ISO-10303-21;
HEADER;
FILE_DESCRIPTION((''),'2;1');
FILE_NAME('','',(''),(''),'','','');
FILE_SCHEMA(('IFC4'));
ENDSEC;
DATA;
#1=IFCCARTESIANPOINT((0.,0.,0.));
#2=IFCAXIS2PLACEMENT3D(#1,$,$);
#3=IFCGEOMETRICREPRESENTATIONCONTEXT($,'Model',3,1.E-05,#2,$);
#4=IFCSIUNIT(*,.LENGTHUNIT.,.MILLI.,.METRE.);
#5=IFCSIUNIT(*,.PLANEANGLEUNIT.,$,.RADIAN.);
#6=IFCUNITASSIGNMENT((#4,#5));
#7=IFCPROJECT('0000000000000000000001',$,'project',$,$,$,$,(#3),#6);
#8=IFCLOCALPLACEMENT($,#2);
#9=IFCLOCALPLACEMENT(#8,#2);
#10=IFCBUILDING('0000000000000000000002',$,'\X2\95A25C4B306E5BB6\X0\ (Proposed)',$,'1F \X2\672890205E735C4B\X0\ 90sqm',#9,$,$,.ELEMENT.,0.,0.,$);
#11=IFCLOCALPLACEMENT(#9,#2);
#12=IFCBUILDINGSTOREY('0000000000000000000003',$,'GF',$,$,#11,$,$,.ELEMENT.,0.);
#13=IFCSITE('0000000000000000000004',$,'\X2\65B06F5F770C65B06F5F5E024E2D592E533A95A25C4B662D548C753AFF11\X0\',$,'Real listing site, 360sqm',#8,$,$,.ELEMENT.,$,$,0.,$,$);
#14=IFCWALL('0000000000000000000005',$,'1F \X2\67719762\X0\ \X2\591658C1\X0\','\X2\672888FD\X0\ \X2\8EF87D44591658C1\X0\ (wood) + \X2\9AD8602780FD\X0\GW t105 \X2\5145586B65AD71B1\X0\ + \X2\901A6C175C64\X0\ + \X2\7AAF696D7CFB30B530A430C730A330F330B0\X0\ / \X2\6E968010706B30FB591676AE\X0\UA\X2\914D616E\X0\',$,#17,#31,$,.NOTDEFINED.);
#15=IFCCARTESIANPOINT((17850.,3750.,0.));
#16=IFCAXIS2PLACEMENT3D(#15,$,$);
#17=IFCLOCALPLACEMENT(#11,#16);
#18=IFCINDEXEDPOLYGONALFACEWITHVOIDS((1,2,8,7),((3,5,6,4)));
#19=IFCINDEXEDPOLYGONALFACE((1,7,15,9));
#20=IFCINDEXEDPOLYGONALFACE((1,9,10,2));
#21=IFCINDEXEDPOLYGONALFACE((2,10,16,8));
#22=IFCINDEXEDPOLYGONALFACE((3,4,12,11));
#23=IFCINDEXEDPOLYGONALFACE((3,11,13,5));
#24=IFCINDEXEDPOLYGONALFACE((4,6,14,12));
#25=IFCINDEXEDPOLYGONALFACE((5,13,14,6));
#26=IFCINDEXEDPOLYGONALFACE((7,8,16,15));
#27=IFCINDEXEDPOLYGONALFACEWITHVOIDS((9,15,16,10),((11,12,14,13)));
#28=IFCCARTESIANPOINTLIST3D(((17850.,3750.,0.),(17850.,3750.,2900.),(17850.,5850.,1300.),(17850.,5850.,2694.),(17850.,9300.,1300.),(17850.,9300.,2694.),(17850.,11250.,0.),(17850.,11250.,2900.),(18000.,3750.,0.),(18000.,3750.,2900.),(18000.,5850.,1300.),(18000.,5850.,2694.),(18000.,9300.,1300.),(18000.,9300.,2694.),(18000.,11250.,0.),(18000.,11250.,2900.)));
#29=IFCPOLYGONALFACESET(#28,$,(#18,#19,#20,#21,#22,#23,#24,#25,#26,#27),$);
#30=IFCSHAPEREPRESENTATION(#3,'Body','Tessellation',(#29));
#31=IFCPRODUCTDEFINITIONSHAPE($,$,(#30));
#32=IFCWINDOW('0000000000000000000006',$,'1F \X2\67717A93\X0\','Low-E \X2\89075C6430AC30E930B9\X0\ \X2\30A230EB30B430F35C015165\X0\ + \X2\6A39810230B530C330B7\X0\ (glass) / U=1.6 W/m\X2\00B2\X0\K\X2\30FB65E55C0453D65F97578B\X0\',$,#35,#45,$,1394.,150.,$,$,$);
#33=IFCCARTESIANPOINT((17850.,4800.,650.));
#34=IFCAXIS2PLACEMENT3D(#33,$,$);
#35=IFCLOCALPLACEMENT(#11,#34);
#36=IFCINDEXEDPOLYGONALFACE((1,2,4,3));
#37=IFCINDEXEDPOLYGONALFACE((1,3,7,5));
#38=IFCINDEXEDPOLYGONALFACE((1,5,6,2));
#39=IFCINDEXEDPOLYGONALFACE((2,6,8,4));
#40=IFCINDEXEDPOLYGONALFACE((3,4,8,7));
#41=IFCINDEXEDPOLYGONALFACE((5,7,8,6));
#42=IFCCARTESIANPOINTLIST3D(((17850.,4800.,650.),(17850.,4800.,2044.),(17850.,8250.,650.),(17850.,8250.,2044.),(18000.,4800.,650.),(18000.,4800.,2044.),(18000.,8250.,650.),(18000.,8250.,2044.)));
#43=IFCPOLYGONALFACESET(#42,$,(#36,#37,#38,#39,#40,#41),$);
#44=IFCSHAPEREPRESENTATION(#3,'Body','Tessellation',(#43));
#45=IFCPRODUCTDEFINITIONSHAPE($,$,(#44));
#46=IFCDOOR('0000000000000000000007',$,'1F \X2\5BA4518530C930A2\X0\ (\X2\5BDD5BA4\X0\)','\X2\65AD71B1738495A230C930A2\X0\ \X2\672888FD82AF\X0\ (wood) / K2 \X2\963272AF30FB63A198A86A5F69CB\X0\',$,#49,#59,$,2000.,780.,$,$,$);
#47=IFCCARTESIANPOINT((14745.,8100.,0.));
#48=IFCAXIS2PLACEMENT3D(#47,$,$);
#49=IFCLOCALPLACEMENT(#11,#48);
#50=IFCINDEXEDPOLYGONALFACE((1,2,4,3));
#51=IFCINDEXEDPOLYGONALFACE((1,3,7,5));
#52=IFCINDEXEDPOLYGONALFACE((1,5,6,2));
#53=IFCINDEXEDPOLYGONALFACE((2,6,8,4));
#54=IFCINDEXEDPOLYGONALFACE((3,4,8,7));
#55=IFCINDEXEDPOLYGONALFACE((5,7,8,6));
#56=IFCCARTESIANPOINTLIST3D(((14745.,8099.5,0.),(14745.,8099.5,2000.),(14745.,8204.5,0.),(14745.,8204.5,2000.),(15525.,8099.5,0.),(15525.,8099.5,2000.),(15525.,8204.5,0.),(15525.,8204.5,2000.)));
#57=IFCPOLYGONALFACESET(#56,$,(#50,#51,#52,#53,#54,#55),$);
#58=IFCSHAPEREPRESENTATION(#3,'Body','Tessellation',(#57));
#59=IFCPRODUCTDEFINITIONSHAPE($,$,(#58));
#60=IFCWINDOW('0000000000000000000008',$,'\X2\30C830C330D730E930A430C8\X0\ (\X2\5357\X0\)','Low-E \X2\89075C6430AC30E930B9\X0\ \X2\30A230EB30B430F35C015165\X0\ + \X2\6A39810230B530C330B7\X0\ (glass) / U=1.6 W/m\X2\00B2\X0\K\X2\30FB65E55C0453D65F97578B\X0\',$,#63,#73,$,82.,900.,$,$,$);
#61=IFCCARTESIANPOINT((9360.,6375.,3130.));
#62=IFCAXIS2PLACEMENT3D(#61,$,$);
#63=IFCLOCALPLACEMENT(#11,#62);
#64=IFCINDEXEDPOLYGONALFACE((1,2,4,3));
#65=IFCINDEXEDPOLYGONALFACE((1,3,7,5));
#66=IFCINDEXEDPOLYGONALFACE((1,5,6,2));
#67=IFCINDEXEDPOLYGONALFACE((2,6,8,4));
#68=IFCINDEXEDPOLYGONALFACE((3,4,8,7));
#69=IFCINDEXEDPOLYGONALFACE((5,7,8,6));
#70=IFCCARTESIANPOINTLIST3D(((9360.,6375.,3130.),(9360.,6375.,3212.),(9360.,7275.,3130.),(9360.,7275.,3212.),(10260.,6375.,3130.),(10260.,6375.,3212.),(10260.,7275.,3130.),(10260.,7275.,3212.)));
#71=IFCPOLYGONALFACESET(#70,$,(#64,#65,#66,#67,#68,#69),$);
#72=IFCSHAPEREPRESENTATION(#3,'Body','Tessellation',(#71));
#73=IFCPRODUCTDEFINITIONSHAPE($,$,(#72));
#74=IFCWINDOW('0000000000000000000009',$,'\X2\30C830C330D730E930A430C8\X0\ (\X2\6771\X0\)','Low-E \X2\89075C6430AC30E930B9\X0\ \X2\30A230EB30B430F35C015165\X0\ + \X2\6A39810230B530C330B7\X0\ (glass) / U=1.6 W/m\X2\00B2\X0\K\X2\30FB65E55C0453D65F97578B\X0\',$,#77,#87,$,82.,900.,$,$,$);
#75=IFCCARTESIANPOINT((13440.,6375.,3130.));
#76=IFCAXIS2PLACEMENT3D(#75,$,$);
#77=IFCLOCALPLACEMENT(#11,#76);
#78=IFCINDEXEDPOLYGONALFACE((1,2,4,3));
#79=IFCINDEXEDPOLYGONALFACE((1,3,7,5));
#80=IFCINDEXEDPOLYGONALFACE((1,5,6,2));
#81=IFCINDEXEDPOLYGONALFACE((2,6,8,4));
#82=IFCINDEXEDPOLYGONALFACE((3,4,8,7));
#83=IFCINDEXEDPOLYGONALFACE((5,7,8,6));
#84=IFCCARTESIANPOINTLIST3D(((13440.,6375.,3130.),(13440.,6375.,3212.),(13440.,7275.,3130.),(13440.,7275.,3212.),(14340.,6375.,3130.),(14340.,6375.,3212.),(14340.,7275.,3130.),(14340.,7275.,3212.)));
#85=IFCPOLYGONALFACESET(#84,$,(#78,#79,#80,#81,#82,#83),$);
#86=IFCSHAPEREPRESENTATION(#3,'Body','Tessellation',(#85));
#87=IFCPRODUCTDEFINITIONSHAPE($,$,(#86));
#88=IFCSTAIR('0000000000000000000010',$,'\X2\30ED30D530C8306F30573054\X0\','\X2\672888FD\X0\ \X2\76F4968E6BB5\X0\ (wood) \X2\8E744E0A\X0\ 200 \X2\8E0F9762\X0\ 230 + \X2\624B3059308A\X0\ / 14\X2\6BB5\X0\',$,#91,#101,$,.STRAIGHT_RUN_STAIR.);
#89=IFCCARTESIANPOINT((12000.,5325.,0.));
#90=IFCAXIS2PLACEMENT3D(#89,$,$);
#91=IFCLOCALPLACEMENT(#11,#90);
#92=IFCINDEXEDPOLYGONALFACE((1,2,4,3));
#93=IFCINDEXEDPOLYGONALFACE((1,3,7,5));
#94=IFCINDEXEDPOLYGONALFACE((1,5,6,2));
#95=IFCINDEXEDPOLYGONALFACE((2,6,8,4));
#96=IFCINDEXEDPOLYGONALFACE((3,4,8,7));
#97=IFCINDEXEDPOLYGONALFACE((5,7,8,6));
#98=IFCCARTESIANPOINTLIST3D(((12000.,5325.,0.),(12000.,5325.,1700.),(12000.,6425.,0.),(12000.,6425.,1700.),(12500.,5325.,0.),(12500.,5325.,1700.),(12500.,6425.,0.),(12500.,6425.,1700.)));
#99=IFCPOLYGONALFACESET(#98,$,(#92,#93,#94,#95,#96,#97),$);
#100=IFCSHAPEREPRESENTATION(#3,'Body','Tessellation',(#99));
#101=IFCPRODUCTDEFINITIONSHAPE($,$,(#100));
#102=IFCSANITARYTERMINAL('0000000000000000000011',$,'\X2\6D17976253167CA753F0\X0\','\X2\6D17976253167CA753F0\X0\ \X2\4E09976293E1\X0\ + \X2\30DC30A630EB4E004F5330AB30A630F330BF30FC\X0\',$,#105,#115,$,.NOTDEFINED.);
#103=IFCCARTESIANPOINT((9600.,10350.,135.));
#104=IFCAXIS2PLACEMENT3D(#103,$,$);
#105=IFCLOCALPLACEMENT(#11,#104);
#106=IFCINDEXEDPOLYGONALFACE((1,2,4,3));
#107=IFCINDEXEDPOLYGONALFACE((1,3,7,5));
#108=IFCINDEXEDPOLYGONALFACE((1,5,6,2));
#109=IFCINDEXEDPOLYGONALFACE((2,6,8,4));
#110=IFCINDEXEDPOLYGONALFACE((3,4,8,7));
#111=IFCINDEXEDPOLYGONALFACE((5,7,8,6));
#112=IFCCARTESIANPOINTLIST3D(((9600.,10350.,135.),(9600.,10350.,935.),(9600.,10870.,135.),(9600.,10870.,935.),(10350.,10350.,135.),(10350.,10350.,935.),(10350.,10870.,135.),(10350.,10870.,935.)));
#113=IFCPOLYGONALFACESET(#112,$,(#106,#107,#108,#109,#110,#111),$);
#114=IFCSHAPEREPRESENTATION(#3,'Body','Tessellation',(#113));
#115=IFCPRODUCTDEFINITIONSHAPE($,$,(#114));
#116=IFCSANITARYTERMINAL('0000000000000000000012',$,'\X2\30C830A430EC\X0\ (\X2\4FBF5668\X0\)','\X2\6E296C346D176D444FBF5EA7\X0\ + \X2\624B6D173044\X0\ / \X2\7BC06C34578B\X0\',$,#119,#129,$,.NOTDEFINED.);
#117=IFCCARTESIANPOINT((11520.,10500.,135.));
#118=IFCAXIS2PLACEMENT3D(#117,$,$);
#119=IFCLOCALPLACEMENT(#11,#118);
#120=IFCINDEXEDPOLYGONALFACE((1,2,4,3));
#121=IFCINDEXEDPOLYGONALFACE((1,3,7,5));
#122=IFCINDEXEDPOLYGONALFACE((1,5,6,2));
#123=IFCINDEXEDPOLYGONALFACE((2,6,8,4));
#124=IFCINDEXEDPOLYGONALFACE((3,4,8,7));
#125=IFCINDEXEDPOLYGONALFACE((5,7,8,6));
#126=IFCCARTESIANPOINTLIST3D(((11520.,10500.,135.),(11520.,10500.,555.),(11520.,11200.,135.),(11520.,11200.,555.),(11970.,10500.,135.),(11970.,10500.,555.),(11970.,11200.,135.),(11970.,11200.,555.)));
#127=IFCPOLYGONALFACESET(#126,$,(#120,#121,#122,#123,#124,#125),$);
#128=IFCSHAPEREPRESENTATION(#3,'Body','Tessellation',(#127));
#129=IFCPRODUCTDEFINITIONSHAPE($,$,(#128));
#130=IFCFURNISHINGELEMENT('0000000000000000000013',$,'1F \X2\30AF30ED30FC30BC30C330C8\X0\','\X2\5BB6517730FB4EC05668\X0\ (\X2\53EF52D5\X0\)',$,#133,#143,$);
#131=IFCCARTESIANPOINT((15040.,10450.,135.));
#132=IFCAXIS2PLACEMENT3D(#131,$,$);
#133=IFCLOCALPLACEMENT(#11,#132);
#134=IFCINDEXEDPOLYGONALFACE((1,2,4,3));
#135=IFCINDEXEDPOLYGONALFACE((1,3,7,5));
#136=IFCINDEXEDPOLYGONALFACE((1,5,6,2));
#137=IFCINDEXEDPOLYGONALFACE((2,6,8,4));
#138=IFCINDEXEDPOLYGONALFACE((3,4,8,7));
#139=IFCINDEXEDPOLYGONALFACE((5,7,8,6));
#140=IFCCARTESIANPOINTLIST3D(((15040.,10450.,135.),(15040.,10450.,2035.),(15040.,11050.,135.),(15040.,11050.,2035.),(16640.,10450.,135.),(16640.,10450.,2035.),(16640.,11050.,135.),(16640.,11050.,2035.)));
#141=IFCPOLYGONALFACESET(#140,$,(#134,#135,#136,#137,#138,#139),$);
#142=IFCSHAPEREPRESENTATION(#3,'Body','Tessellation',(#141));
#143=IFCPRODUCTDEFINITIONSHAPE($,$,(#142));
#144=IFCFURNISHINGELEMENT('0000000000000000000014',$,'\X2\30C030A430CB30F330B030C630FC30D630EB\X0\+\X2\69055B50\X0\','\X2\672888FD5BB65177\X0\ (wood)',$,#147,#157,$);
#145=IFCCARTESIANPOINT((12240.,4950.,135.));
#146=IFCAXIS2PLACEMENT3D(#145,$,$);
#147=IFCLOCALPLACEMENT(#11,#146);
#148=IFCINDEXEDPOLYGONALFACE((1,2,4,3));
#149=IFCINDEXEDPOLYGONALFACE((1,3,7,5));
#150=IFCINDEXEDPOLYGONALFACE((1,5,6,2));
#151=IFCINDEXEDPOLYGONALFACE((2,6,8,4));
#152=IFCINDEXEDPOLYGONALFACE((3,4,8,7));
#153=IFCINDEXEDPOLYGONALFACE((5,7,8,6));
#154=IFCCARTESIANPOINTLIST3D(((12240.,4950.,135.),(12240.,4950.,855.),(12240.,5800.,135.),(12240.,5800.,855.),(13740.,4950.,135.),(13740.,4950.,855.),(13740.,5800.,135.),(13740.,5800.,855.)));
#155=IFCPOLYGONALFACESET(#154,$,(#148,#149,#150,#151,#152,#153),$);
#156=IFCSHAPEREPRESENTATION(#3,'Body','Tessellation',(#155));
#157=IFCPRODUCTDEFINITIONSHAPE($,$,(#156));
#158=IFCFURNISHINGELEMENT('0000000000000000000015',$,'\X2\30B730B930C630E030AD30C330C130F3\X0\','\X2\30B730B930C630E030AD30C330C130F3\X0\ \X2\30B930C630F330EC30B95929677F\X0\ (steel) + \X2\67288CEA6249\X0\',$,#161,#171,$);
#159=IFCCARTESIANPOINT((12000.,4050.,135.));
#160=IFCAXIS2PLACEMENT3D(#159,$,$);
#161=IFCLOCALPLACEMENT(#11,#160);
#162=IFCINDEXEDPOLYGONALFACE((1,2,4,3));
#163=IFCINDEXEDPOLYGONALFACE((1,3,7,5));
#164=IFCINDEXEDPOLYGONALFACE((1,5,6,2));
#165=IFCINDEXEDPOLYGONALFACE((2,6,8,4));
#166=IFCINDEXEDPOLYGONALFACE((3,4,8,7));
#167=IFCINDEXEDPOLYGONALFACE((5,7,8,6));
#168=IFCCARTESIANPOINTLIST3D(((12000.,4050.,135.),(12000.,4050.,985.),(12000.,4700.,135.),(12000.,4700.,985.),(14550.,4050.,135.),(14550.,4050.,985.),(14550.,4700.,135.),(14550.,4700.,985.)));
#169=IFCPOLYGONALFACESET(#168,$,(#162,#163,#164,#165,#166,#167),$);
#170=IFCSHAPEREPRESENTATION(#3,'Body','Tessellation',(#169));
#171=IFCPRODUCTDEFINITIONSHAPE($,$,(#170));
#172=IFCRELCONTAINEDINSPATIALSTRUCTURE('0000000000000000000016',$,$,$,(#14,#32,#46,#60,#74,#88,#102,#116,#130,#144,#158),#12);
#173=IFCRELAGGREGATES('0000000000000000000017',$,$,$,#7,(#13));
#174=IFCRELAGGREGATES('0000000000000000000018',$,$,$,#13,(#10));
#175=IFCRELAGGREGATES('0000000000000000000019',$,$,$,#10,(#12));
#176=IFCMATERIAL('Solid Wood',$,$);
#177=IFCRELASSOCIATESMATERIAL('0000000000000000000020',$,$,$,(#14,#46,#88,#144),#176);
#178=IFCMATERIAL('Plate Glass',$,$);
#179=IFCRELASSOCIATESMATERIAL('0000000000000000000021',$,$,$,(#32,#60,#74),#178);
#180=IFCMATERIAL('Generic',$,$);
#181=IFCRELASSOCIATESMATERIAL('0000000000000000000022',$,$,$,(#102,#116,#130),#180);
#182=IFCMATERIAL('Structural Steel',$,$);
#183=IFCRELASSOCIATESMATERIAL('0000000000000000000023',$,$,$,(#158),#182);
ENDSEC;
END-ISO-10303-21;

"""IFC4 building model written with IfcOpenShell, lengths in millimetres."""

from ifc_helpers import new_model, si_unit, frame, frame_2d, origin, place, context, project, spatial, rectangle, extrude, material, element, fill, save


model = new_model("IFC4")

# Units and contexts
model_context = context("Model", 3, precision=1e-05, world=origin())
ifc_project = project(units=[si_unit("LENGTHUNIT", "METRE", prefix="MILLI"), si_unit("PLANEANGLEUNIT", "RADIAN")], contexts=[model_context])

# Site, building, storey
site_placement = place(None, origin())
site = spatial("IfcSite", under=ifc_project, at=site_placement, Name="新潟県新潟市中央区関屋昭和町１", ObjectType="Real listing site, 360sqm", CompositionType="ELEMENT", RefElevation=0.0)
building_placement = place(site_placement, origin())
building = spatial("IfcBuilding", under=site, at=building_placement, Name="関屋の家 (Proposed)", ObjectType="1F 木造平屋 90sqm", CompositionType="ELEMENT", ElevationOfRefHeight=0.0, ElevationOfTerrain=0.0)
storey_placement = place(building_placement, origin())
storey = spatial("IfcBuildingStorey", under=building, at=storey_placement, Name="GF", CompositionType="ELEMENT", Elevation=0.0)

# Wall, opening, window
ifc_material_1 = material(Name="Solid Wood")
wall_1_placement = place(storey_placement, frame((17850.0, 3750.0, 0.0)))
wall_1 = element("IfcWall", 1, at=wall_1_placement, inside=storey, material=ifc_material_1, Name="1F 東面 外壁", Description="木製 軸組外壁 (wood) + 高性能GW t105 充填断熱 + 通気層 + 窯業系サイディング / 準耐火・外皮UA配慮", PredefinedType="NOTDEFINED", context=model_context, shape_type="SweptSolid", body=[
    extrude(rectangle(XDim=150.0, YDim=7500.0, at=frame_2d((75.0, 3750.0))), frame((17850.0, 3750.0, 0.0)), (0.0, 0.0, 1.0), 2900.0),
])
opening_placement = place(storey_placement, frame((17850.0, 4800.0, 650.0)))
opening = element("IfcOpeningElement", 2, at=opening_placement, cuts=wall_1, PredefinedType="NOTDEFINED", context=model_context, shape_type="SweptSolid", body=[
    extrude(rectangle(XDim=150.0, YDim=3450.0, at=frame_2d((75.0, 1725.0))), frame((17850.0, 4800.0, 650.0)), (0.0, 0.0, 1.0), 1394.0),
])
ifc_material_2 = material(Name="Plate Glass")
window_1_placement = place(storey_placement, frame((17850.0, 4800.0, 650.0)))
window_1 = element("IfcWindow", 3, at=window_1_placement, inside=storey, material=ifc_material_2, Name="1F 東窓", Description="Low-E 複層ガラス アルゴン封入 + 樹脂サッシ (glass) / U=1.6 W/m²K・日射取得型", OverallHeight=1394.0, OverallWidth=150.0, context=model_context, shape_type="SweptSolid", body=[
    extrude(rectangle(XDim=150.0, YDim=3450.0, at=frame_2d((75.0, 1725.0))), frame((17850.0, 4800.0, 650.0)), (0.0, 0.0, 1.0), 1394.0),
])
fill(opening, window_1)

# Door
door_placement = place(storey_placement, frame((14745.0, 8100.0, 0.0)))
element("IfcDoor", 4, at=door_placement, inside=storey, material=ifc_material_1, Name="1F 室内ドア (寝室)", Description="断熱玄関ドア 木製芯 (wood) / K2 防犯・採風機構", OverallHeight=2000.0, OverallWidth=780.0, context=model_context, shape_type="SweptSolid", body=[
    extrude(rectangle(XDim=780.0, YDim=105.0, at=frame_2d((390.0, 52.0))), frame((14745.0, 8100.0, 0.0)), (0.0, 0.0, 1.0), 2000.0),
])

# Windows
window_2_placement = place(storey_placement, frame((9360.0, 6375.0, 3130.0)))
element("IfcWindow", 5, at=window_2_placement, inside=storey, material=ifc_material_2, Name="トップライト (南)", Description="Low-E 複層ガラス アルゴン封入 + 樹脂サッシ (glass) / U=1.6 W/m²K・日射取得型", OverallHeight=82.0, OverallWidth=900.0, context=model_context, shape_type="SweptSolid", body=[
    extrude(rectangle(XDim=900.0, YDim=900.0, at=frame_2d((450.0, 450.0))), frame((9360.0, 6375.0, 3130.0)), (0.0, 0.0, 1.0), 82.0),
])
window_3_placement = place(storey_placement, frame((13440.0, 6375.0, 3130.0)))
element("IfcWindow", 6, at=window_3_placement, inside=storey, material=ifc_material_2, Name="トップライト (東)", Description="Low-E 複層ガラス アルゴン封入 + 樹脂サッシ (glass) / U=1.6 W/m²K・日射取得型", OverallHeight=82.0, OverallWidth=900.0, context=model_context, shape_type="SweptSolid", body=[
    extrude(rectangle(XDim=900.0, YDim=900.0, at=frame_2d((450.0, 450.0))), frame((13440.0, 6375.0, 3130.0)), (0.0, 0.0, 1.0), 82.0),
])

# Stair
stair_placement = place(storey_placement, frame((12000.0, 5325.0, 0.0)))
element("IfcStair", 7, at=stair_placement, inside=storey, material=ifc_material_1, Name="ロフトはしご", Description="木製 直階段 (wood) 蹴上 200 踏面 230 + 手すり / 14段", PredefinedType="STRAIGHT_RUN_STAIR", context=model_context, shape_type="SweptSolid", body=[
    extrude(rectangle(XDim=500.0, YDim=1100.0, at=frame_2d((250.0, 550.0))), frame((12000.0, 5325.0, 0.0)), (0.0, 0.0, 1.0), 1700.0),
])

# Sanitary terminals
ifc_material_3 = material(Name="Generic")
sanitary_terminal_1_placement = place(storey_placement, frame((9600.0, 10350.0, 135.0)))
element("IfcSanitaryTerminal", 8, at=sanitary_terminal_1_placement, inside=storey, material=ifc_material_3, Name="洗面化粧台", Description="洗面化粧台 三面鏡 + ボウル一体カウンター", PredefinedType="NOTDEFINED", context=model_context, shape_type="SweptSolid", body=[
    extrude(rectangle(XDim=750.0, YDim=520.0, at=frame_2d((375.0, 260.0))), frame((9600.0, 10350.0, 135.0)), (0.0, 0.0, 1.0), 800.0),
])
sanitary_terminal_2_placement = place(storey_placement, frame((11520.0, 10500.0, 135.0)))
element("IfcSanitaryTerminal", 9, at=sanitary_terminal_2_placement, inside=storey, material=ifc_material_3, Name="トイレ (便器)", Description="温水洗浄便座 + 手洗い / 節水型", PredefinedType="NOTDEFINED", context=model_context, shape_type="SweptSolid", body=[
    extrude(rectangle(XDim=450.0, YDim=700.0, at=frame_2d((225.0, 350.0))), frame((11520.0, 10500.0, 135.0)), (0.0, 0.0, 1.0), 420.0),
])

# Furnishing elements
furnishing_1_placement = place(storey_placement, frame((15040.0, 10450.0, 135.0)))
element("IfcFurnishingElement", 10, at=furnishing_1_placement, inside=storey, material=ifc_material_3, Name="1F クローゼット", Description="家具・什器 (可動)", context=model_context, shape_type="SweptSolid", body=[
    extrude(rectangle(XDim=1600.0, YDim=600.0, at=frame_2d((800.0, 300.0))), frame((15040.0, 10450.0, 135.0)), (0.0, 0.0, 1.0), 1900.0),
])
furnishing_2_placement = place(storey_placement, frame((12240.0, 4950.0, 135.0)))
element("IfcFurnishingElement", 11, at=furnishing_2_placement, inside=storey, material=ifc_material_1, Name="ダイニングテーブル+椅子", Description="木製家具 (wood)", context=model_context, shape_type="SweptSolid", body=[
    extrude(rectangle(XDim=1500.0, YDim=850.0, at=frame_2d((750.0, 425.0))), frame((12240.0, 4950.0, 135.0)), (0.0, 0.0, 1.0), 720.0),
])
ifc_material_4 = material(Name="Structural Steel")
furnishing_3_placement = place(storey_placement, frame((12000.0, 4050.0, 135.0)))
element("IfcFurnishingElement", 12, at=furnishing_3_placement, inside=storey, material=ifc_material_4, Name="システムキッチン", Description="システムキッチン ステンレス天板 (steel) + 木質扉", context=model_context, shape_type="SweptSolid", body=[
    extrude(rectangle(XDim=2550.0, YDim=650.0, at=frame_2d((1275.0, 325.0))), frame((12000.0, 4050.0, 135.0)), (0.0, 0.0, 1.0), 850.0),
])

save(model, "model.ifc")
